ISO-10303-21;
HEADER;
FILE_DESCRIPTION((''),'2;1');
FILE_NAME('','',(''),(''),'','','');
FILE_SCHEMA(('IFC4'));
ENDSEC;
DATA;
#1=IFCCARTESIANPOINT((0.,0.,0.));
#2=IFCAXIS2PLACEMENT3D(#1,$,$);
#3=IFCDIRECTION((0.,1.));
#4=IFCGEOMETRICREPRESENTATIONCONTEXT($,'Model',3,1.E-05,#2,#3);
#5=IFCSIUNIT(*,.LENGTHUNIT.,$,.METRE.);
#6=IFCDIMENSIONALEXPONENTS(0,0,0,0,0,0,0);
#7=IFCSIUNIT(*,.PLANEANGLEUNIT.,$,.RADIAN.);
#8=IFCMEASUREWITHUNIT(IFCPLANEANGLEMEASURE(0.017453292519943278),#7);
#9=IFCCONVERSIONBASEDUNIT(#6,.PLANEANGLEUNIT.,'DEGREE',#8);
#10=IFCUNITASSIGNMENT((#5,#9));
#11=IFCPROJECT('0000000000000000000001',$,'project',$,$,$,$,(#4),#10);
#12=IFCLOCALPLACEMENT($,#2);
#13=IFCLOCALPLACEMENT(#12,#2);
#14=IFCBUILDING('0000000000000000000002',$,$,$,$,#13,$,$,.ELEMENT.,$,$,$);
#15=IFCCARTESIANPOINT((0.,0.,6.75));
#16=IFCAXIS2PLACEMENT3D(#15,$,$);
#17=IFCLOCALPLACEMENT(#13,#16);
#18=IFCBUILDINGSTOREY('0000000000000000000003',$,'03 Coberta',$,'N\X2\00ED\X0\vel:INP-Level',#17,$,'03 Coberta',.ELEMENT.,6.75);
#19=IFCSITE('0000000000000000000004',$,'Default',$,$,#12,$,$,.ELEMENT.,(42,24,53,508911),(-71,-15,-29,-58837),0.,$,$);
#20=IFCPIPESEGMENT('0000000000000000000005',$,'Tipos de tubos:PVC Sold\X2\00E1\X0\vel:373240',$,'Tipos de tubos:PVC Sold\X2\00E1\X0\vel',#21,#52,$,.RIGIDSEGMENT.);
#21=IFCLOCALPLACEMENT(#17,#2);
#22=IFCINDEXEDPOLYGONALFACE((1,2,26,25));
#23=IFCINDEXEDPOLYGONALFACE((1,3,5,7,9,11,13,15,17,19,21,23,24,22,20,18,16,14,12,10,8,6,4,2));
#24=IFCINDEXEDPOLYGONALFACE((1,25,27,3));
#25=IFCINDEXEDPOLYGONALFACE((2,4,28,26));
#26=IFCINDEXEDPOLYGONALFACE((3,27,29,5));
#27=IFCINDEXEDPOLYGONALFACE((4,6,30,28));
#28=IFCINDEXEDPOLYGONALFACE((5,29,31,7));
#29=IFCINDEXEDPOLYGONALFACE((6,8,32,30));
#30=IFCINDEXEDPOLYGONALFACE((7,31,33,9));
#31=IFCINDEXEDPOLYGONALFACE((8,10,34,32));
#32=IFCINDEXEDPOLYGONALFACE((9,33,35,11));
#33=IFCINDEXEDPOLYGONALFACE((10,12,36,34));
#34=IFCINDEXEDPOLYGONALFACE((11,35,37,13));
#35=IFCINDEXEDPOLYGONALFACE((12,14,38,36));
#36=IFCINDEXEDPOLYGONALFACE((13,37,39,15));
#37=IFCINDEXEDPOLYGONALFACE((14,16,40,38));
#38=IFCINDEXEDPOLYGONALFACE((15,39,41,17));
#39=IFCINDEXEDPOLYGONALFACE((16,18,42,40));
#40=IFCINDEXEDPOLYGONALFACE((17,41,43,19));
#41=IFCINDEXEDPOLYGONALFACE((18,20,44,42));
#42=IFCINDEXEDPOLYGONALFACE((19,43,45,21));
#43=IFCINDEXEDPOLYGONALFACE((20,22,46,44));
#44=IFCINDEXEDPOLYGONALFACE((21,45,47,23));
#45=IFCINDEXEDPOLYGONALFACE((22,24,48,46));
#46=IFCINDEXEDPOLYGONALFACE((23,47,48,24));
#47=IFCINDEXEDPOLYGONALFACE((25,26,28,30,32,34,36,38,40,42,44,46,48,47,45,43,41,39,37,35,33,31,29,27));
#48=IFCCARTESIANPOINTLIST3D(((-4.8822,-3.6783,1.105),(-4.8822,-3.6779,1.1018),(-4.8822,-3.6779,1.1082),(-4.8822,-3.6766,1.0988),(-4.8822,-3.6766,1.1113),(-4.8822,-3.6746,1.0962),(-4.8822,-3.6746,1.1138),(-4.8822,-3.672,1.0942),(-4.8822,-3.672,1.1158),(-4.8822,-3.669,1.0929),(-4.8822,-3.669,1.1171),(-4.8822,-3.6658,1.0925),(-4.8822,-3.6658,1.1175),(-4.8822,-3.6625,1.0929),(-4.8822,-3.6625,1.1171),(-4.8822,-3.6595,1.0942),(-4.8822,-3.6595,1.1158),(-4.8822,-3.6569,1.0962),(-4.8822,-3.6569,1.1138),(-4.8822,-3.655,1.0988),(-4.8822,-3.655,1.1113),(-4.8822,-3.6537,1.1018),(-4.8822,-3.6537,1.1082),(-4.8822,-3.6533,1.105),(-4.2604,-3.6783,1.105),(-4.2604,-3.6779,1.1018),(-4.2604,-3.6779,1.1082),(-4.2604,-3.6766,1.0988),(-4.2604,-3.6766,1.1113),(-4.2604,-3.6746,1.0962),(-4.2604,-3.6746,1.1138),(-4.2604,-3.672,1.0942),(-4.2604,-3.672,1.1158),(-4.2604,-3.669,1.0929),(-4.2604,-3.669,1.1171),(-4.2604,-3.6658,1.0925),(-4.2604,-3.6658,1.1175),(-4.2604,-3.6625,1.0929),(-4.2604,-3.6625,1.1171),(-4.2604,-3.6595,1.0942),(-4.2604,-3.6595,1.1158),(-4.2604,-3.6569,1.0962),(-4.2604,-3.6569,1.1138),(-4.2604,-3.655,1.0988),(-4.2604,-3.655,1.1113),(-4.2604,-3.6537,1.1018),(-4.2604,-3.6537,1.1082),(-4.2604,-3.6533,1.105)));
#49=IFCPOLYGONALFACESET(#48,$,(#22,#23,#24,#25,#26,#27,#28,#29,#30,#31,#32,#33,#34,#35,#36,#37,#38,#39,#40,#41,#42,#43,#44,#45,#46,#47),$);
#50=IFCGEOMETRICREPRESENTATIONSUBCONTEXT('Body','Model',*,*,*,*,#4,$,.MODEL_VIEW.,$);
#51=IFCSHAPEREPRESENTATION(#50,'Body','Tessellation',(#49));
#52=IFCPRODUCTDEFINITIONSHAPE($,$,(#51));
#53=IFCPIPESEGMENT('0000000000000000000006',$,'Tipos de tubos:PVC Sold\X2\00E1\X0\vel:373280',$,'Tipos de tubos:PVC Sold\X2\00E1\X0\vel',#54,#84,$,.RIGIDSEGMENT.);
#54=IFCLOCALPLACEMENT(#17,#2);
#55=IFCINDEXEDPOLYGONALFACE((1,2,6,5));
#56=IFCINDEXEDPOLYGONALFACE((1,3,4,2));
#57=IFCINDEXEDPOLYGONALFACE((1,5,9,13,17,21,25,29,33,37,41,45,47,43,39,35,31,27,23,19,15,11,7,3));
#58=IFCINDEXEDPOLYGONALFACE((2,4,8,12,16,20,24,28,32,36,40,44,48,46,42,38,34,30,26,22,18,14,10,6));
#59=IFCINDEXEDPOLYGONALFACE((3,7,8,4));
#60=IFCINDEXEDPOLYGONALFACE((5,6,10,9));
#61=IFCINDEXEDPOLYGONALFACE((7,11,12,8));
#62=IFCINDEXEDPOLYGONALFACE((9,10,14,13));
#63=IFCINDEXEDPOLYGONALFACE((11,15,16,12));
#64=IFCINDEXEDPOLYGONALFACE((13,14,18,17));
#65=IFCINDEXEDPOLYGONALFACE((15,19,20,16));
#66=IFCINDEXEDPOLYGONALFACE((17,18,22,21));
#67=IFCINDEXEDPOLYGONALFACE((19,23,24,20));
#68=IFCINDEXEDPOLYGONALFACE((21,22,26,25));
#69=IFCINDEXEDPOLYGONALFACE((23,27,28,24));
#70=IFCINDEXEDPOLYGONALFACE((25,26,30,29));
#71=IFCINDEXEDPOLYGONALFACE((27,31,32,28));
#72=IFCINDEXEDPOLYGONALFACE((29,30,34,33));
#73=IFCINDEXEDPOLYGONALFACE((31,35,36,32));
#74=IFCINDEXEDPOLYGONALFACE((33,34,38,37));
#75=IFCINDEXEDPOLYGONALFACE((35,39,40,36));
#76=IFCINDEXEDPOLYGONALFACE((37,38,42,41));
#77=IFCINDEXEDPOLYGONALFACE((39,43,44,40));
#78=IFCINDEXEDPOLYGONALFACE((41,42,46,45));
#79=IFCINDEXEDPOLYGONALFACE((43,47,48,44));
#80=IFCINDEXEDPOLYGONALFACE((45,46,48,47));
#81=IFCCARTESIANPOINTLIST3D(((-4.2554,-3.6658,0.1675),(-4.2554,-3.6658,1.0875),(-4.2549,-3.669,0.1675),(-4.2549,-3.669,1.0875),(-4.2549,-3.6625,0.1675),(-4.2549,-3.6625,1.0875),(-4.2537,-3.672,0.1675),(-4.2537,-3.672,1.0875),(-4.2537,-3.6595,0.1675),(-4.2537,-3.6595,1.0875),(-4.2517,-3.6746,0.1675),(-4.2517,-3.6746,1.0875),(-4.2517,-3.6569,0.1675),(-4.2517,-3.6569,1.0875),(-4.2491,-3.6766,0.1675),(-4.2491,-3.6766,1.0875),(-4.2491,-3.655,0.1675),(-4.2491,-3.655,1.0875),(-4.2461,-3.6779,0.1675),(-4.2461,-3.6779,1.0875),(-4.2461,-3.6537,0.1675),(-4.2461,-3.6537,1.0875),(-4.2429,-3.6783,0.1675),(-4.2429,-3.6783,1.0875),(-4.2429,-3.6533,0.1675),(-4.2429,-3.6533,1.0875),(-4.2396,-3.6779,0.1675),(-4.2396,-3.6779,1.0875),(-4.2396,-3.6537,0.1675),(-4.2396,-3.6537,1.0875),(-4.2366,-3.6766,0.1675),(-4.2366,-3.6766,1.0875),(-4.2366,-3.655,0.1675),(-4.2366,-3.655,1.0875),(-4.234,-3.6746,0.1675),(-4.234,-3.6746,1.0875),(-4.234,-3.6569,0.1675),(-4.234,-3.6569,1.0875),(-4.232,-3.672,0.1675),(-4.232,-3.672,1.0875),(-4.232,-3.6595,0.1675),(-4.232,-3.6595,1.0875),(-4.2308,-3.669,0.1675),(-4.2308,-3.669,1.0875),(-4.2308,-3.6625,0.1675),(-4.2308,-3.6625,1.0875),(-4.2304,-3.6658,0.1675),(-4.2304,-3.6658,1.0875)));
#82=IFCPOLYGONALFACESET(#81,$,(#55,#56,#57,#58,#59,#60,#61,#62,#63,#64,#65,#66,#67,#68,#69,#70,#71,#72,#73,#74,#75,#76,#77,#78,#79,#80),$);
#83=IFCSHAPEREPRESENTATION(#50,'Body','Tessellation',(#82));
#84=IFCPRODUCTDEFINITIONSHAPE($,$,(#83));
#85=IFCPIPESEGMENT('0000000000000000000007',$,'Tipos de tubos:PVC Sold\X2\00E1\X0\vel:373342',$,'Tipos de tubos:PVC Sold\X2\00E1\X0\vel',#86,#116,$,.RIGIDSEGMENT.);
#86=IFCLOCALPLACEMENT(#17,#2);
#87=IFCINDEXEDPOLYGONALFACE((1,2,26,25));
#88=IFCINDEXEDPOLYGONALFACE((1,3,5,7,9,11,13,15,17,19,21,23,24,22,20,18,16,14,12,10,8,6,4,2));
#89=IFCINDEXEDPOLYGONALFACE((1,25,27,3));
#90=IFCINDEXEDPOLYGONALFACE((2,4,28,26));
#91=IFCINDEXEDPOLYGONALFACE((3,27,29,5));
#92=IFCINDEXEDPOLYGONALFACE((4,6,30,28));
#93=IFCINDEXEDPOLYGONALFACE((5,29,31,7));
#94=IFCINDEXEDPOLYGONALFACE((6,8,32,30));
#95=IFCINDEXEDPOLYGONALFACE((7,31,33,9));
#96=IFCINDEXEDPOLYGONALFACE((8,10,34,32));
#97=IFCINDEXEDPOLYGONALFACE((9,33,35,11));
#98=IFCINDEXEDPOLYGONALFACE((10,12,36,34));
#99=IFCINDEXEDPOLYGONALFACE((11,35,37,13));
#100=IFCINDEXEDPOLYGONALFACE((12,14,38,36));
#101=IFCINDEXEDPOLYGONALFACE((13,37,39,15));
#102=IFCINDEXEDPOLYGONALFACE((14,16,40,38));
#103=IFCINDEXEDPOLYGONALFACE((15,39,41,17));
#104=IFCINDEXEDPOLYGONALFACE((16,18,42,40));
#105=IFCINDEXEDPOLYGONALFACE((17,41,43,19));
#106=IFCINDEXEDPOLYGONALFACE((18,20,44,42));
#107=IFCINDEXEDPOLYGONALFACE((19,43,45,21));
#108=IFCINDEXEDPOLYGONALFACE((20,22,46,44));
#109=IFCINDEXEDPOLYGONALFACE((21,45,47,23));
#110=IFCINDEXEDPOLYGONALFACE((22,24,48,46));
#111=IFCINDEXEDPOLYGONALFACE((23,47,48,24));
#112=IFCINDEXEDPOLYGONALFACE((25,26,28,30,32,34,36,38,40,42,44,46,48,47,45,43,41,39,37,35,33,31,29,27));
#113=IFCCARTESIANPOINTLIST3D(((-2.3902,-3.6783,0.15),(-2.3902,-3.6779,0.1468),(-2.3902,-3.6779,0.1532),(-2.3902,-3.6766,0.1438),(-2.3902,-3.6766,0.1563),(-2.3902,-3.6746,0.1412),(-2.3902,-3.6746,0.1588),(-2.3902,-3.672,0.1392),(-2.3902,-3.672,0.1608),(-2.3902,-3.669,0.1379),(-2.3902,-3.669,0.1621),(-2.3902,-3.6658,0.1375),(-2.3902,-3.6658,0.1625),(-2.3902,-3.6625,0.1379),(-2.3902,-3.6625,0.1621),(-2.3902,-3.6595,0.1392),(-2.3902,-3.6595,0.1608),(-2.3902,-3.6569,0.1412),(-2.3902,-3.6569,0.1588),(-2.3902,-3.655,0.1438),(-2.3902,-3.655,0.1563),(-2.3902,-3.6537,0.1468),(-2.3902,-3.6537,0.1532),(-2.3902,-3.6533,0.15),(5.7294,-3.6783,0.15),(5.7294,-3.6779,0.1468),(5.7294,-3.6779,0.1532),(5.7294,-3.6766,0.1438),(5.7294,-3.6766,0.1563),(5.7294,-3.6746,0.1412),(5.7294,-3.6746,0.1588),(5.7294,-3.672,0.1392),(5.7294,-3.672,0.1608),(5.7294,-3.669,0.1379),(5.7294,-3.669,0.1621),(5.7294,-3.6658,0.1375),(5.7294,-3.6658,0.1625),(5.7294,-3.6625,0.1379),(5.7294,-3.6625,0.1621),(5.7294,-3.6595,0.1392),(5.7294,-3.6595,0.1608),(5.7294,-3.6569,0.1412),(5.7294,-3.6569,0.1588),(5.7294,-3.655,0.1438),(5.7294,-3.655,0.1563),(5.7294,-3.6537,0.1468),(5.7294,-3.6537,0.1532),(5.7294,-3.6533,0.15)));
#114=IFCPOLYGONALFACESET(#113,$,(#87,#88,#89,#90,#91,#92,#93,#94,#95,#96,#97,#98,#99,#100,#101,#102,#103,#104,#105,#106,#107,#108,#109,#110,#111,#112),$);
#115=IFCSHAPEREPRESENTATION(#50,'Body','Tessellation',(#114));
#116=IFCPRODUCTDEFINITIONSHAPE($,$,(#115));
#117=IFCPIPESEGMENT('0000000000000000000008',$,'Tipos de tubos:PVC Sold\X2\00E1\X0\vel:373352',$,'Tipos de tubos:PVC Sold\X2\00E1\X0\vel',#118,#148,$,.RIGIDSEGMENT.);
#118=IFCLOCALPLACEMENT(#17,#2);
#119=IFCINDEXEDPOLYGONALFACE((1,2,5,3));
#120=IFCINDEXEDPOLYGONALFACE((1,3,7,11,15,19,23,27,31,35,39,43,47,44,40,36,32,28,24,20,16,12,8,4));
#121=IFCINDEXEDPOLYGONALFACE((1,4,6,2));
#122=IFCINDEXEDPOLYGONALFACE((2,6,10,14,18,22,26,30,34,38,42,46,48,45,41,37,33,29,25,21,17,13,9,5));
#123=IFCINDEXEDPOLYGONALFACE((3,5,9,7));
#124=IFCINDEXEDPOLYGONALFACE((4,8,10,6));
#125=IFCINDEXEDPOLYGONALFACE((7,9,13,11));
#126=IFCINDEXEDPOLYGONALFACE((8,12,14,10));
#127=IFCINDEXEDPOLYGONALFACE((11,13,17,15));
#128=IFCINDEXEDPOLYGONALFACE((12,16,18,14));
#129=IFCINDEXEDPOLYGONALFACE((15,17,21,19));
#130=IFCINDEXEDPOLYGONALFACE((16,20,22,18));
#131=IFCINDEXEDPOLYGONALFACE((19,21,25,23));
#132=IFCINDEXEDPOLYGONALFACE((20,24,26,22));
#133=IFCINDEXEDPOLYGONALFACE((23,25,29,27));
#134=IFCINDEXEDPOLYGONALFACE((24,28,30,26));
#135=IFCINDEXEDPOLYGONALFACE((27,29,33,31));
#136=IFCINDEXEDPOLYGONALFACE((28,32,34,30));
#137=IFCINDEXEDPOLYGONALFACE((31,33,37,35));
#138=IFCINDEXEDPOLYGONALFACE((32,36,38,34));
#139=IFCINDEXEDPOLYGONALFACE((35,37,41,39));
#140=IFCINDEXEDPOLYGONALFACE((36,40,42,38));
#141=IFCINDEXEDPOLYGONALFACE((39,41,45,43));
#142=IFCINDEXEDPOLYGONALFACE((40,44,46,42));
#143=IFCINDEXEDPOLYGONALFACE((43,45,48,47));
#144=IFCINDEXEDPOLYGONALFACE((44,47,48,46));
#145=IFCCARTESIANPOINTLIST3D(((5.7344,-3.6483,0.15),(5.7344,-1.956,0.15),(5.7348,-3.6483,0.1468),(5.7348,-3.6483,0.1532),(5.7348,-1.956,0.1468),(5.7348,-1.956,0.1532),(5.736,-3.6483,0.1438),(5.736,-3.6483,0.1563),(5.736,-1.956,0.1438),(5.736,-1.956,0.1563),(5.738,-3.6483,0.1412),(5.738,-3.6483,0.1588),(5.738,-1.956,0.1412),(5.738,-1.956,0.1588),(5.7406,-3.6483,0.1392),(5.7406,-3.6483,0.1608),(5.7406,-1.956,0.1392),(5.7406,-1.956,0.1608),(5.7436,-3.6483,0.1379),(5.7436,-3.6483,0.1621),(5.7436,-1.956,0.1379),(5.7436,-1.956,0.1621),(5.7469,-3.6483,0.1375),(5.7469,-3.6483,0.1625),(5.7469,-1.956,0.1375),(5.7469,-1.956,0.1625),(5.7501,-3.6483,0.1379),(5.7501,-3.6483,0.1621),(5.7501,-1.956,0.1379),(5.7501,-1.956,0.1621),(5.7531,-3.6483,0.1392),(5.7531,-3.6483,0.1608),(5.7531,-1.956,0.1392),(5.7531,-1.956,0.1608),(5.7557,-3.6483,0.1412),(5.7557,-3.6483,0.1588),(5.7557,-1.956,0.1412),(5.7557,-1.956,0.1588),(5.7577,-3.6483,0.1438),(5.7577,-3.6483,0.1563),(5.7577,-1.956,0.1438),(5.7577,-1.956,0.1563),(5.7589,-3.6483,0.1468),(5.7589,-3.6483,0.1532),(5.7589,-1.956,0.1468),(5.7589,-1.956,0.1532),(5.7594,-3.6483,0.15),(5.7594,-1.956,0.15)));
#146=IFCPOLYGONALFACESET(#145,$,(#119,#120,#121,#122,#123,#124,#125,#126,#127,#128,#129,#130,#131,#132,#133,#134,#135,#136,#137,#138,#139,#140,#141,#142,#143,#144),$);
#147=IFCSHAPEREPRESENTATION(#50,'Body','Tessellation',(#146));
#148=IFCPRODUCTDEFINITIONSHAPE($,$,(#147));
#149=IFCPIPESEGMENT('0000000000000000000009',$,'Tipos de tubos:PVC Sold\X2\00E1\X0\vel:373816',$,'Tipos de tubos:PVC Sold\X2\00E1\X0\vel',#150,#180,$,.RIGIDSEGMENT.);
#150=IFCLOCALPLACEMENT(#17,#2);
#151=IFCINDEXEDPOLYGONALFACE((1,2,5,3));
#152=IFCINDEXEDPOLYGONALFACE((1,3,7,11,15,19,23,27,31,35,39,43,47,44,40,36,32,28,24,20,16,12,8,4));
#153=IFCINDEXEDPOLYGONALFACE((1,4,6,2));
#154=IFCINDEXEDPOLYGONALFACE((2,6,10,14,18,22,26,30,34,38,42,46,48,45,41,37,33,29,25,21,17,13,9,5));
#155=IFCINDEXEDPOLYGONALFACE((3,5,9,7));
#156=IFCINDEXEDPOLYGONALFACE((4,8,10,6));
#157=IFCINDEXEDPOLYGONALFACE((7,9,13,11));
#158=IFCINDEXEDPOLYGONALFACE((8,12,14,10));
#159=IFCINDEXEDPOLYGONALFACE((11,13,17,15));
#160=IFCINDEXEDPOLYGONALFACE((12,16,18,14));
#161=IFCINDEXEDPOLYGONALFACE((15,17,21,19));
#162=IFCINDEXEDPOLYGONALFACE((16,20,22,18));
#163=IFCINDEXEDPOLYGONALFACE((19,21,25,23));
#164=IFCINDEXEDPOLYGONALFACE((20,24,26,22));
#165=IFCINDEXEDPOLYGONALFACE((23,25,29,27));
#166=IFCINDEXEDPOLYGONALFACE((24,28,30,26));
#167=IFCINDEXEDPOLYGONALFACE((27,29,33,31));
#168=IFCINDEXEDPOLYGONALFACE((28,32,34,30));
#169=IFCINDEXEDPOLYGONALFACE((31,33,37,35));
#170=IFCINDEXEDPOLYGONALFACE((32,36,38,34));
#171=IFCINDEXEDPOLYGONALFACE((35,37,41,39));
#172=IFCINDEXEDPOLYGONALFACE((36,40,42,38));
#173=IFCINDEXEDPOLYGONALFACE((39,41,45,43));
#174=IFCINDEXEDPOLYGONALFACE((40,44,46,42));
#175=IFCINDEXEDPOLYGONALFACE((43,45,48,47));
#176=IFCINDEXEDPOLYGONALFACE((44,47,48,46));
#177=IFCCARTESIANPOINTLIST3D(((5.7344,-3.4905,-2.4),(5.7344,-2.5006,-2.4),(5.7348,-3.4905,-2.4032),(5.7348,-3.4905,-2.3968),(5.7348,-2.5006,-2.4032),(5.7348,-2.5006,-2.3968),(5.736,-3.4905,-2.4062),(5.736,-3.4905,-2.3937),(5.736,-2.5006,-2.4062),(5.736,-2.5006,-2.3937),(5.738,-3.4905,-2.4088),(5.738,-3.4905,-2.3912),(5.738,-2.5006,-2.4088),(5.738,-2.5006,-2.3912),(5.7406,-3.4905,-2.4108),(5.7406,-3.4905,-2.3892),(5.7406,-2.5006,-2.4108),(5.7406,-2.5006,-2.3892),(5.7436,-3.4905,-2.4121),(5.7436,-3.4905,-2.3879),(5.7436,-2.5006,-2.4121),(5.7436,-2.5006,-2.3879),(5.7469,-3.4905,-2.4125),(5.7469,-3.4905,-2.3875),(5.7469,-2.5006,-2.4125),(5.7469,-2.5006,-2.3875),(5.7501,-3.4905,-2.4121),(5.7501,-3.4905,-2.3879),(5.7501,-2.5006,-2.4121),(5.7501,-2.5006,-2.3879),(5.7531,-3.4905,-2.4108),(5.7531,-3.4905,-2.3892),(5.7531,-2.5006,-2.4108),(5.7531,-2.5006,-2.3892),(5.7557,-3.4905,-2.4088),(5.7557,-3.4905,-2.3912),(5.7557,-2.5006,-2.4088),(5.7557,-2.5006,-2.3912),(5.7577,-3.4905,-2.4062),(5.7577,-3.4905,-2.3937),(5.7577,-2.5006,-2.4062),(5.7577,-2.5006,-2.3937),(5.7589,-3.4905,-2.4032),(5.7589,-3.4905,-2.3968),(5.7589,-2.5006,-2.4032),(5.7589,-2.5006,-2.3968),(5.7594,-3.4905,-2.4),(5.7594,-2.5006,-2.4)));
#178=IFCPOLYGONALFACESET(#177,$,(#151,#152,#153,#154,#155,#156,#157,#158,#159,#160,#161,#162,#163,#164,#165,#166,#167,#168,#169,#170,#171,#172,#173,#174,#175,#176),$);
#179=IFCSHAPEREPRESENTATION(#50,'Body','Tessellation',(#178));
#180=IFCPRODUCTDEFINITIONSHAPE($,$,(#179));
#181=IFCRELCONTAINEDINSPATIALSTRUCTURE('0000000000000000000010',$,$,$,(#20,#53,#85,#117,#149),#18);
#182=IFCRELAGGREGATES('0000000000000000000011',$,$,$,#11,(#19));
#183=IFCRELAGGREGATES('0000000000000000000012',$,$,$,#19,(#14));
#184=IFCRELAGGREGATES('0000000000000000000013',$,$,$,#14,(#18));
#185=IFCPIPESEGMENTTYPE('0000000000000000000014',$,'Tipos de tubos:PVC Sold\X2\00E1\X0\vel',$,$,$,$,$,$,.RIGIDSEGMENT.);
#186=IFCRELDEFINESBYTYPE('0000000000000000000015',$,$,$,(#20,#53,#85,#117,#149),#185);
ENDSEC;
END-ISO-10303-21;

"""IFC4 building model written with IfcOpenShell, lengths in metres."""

from ifc_helpers import new_model, entity, si_unit, converted_unit, direction, frame, origin, place, context, subcontext, project, spatial, arc, indexed_curve, outline, extrude, type_object, element, save


model = new_model("IFC4")

# Units and contexts
model_context = context("Model", 3, precision=1e-05, world=origin(), true_north=direction((0.0, 1.0)))
body_context = subcontext(model_context, "Body", "Model", "MODEL_VIEW")
ifc_project = project(units=[si_unit("LENGTHUNIT", "METRE"), converted_unit("PLANEANGLEUNIT", "DEGREE", entity("IfcPlaneAngleMeasure", 0.017453292519943278), si_unit("PLANEANGLEUNIT", "RADIAN"), dimensions=[0, 0, 0, 0, 0, 0, 0])], contexts=[model_context])

# Site, building, storey
site_placement = place(None, origin())
site = spatial("IfcSite", under=ifc_project, at=site_placement, Name="Default", CompositionType="ELEMENT", RefLatitude=(42, 24, 53, 508911), RefLongitude=(-71, -15, -29, -58837), RefElevation=0.0)
building_placement = place(site_placement, origin())
building = spatial("IfcBuilding", under=site, at=building_placement, CompositionType="ELEMENT")
storey_placement = place(building_placement, frame((0.0, 0.0, 6.75)))
storey = spatial("IfcBuildingStorey", under=building, at=storey_placement, Name="03 Coberta", ObjectType="Nível:INP-Level", LongName="03 Coberta", CompositionType="ELEMENT", Elevation=6.75)

# Pipe segments
pipe_segment_type = type_object("IfcPipeSegmentType", Name="Tipos de tubos:PVC Soldável", PredefinedType="RIGIDSEGMENT")
pipe_segment_1_placement = place(storey_placement, origin())
element("IfcPipeSegment", 1, at=pipe_segment_1_placement, inside=storey, type_object=pipe_segment_type, Name="Tipos de tubos:PVC Soldável:373240", ObjectType="Tipos de tubos:PVC Soldável", PredefinedType="RIGIDSEGMENT", context=body_context, shape_type="SweptSolid", body=[
    extrude(outline(indexed_curve([(0.0125, 0.0), (0.0088, 0.0088), (0.0, 0.0125), (-0.0088, 0.0088), (-0.0125, 0.0), (-0.0088, -0.0088), (0.0, -0.0125), (0.0088, -0.0088)], segments=[arc(1, 2, 3), arc(3, 4, 5), arc(5, 6, 7), arc(7, 8, 1)], self_intersect=False)), frame((-4.8822, -3.6658, 1.105), z_axis=(1.0, 0.0, 0.0), x_axis=(0.0, 1.0, 0.0)), (0.0, 0.0, 1.0), 0.6219),
])
pipe_segment_2_placement = place(storey_placement, origin())
element("IfcPipeSegment", 2, at=pipe_segment_2_placement, inside=storey, type_object=pipe_segment_type, Name="Tipos de tubos:PVC Soldável:373280", ObjectType="Tipos de tubos:PVC Soldável", PredefinedType="RIGIDSEGMENT", context=body_context, shape_type="SweptSolid", body=[
    extrude(outline(indexed_curve([(0.0125, 0.0), (0.0088, 0.0088), (0.0, 0.0125), (-0.0088, 0.0088), (-0.0125, 0.0), (-0.0088, -0.0088), (0.0, -0.0125), (0.0088, -0.0088)], segments=[arc(1, 2, 3), arc(3, 4, 5), arc(5, 6, 7), arc(7, 8, 1)], self_intersect=False)), frame((-4.2429, -3.6658, 0.1675)), (0.0, 0.0, 1.0), 0.92),
])
pipe_segment_3_placement = place(storey_placement, origin())
element("IfcPipeSegment", 3, at=pipe_segment_3_placement, inside=storey, type_object=pipe_segment_type, Name="Tipos de tubos:PVC Soldável:373342", ObjectType="Tipos de tubos:PVC Soldável", PredefinedType="RIGIDSEGMENT", context=body_context, shape_type="SweptSolid", body=[
    extrude(outline(indexed_curve([(0.0125, 0.0), (0.0088, 0.0088), (0.0, 0.0125), (-0.0088, 0.0088), (-0.0125, 0.0), (-0.0088, -0.0088), (0.0, -0.0125), (0.0088, -0.0088)], segments=[arc(1, 2, 3), arc(3, 4, 5), arc(5, 6, 7), arc(7, 8, 1)], self_intersect=False)), frame((-2.3902, -3.6658, 0.15), z_axis=(1.0, 0.0, 0.0), x_axis=(0.0, -1.0, 0.0)), (0.0, 0.0, 1.0), 8.1196),
])
pipe_segment_4_placement = place(storey_placement, origin())
element("IfcPipeSegment", 4, at=pipe_segment_4_placement, inside=storey, type_object=pipe_segment_type, Name="Tipos de tubos:PVC Soldável:373352", ObjectType="Tipos de tubos:PVC Soldável", PredefinedType="RIGIDSEGMENT", context=body_context, shape_type="SweptSolid", body=[
    extrude(outline(indexed_curve([(0.0125, 0.0), (0.0088, 0.0088), (0.0, 0.0125), (-0.0088, 0.0088), (-0.0125, 0.0), (-0.0088, -0.0088), (0.0, -0.0125), (0.0088, -0.0088)], segments=[arc(1, 2, 3), arc(3, 4, 5), arc(5, 6, 7), arc(7, 8, 1)], self_intersect=False)), frame((5.7469, -3.6483, 0.15), z_axis=(0.0, 1.0, 0.0), x_axis=(1.0, 0.0, 0.0)), (0.0, 0.0, 1.0), 1.6922),
])
pipe_segment_5_placement = place(storey_placement, origin())
element("IfcPipeSegment", 5, at=pipe_segment_5_placement, inside=storey, type_object=pipe_segment_type, Name="Tipos de tubos:PVC Soldável:373816", ObjectType="Tipos de tubos:PVC Soldável", PredefinedType="RIGIDSEGMENT", context=body_context, shape_type="SweptSolid", body=[
    extrude(outline(indexed_curve([(0.0125, 0.0), (0.0088, 0.0088), (0.0, 0.0125), (-0.0088, 0.0088), (-0.0125, 0.0), (-0.0088, -0.0088), (0.0, -0.0125), (0.0088, -0.0088)], segments=[arc(1, 2, 3), arc(3, 4, 5), arc(5, 6, 7), arc(7, 8, 1)], self_intersect=False)), frame((5.7469, -3.4905, -2.4), z_axis=(0.0, 1.0, 0.0), x_axis=(-1.0, 0.0, 0.0)), (0.0, 0.0, 1.0), 0.9898),
])

save(model, "model.ifc")
